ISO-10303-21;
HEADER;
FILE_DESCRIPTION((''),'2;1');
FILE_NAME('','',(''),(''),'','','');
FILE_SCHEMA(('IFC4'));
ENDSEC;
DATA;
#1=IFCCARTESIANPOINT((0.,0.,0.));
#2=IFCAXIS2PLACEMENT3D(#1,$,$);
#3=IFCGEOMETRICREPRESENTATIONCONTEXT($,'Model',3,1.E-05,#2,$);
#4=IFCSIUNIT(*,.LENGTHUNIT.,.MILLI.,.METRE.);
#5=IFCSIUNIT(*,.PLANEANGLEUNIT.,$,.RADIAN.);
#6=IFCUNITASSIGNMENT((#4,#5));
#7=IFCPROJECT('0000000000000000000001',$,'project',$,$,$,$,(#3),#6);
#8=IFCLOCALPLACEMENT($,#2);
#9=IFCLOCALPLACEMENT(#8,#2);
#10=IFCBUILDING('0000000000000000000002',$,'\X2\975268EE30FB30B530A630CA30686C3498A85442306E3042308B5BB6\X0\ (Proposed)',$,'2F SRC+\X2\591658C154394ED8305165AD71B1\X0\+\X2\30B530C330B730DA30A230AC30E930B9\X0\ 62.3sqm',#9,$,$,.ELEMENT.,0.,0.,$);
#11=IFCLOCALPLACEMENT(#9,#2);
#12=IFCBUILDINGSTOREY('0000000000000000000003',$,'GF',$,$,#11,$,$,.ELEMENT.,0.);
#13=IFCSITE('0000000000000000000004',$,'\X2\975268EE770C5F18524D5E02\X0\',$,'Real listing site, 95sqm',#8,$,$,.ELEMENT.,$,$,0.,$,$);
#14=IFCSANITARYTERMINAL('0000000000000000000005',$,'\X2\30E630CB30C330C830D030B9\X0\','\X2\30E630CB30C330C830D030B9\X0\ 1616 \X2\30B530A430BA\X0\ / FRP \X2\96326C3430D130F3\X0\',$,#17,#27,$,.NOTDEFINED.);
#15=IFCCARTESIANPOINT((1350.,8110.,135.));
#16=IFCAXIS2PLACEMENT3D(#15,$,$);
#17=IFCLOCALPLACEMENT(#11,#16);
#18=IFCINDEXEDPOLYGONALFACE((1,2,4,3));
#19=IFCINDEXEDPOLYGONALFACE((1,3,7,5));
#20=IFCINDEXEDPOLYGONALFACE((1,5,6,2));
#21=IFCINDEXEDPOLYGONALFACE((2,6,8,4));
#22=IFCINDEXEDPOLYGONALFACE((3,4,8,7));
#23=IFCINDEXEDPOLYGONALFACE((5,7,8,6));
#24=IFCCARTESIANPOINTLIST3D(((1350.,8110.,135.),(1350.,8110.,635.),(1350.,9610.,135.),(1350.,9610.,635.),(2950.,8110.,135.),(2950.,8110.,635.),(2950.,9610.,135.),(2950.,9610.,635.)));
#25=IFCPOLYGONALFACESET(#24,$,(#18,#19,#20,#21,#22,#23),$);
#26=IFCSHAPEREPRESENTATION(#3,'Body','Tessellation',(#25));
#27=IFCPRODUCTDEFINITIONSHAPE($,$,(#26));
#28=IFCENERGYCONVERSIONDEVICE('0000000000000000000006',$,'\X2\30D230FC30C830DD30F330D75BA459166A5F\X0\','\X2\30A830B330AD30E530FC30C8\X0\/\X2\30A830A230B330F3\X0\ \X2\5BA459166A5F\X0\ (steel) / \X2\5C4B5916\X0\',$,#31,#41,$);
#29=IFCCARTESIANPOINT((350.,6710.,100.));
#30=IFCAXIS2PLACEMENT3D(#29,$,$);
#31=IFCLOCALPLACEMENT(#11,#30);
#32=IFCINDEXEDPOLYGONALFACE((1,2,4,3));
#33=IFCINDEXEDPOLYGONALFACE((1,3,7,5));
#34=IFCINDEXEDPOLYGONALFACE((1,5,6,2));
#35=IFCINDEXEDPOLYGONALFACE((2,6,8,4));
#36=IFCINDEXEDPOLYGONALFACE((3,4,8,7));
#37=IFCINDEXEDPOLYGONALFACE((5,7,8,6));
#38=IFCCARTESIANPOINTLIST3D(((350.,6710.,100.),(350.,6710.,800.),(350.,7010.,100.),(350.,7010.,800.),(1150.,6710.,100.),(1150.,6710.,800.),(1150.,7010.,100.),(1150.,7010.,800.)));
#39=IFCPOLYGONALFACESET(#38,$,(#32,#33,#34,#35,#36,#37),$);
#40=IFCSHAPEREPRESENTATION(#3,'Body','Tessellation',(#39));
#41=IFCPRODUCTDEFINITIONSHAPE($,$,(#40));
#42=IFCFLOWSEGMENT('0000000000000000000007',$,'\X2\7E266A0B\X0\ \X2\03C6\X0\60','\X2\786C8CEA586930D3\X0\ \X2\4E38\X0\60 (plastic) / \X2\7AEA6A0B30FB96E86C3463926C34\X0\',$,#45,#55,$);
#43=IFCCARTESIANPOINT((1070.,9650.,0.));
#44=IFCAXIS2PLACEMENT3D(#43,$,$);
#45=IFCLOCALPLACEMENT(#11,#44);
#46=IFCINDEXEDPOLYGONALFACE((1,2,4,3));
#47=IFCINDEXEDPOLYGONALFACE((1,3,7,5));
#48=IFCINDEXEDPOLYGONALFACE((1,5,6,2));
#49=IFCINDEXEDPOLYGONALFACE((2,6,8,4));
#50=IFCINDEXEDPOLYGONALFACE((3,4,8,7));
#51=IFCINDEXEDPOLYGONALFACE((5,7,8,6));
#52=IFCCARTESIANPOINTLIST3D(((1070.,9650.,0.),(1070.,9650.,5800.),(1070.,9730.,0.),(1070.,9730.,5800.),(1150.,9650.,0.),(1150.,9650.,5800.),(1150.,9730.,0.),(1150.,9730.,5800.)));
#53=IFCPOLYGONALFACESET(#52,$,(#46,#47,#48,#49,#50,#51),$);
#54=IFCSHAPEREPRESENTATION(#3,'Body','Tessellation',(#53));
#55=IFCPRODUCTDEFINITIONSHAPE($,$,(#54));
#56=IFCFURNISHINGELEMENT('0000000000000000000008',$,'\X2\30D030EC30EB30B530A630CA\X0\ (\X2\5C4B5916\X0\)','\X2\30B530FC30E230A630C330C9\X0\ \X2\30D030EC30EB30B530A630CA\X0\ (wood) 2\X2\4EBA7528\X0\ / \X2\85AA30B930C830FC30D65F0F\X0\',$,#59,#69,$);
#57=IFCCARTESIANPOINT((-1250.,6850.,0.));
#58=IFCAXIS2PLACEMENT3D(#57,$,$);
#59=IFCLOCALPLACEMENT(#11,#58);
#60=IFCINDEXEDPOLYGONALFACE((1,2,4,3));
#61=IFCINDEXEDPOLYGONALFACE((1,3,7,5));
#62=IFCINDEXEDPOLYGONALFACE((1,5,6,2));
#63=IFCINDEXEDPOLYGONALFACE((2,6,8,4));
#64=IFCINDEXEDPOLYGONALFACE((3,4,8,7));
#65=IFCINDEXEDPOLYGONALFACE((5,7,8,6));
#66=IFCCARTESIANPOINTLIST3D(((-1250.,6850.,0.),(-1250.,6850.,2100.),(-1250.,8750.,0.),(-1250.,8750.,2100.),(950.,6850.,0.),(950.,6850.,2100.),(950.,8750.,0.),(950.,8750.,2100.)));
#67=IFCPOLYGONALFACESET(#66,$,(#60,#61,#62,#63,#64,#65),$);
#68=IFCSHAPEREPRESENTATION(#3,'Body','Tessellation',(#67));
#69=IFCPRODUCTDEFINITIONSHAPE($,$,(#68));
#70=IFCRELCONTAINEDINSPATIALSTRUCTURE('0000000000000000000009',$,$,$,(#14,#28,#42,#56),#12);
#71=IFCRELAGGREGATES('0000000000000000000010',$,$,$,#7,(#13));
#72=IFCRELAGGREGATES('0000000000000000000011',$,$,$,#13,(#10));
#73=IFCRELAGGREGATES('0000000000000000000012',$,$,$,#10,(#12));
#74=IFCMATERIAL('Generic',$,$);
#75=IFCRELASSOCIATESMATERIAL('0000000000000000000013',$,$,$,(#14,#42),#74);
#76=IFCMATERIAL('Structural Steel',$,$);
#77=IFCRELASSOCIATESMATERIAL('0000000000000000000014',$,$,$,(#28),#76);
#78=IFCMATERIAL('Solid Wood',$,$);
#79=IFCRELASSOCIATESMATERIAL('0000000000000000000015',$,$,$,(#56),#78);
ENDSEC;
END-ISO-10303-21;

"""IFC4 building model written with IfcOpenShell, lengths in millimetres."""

from ifc_helpers import new_model, si_unit, frame, frame_2d, origin, place, context, project, spatial, rectangle, extrude, material, element, save


model = new_model("IFC4")

# Units and contexts
model_context = context("Model", 3, precision=1e-05, world=origin())
ifc_project = project(units=[si_unit("LENGTHUNIT", "METRE", prefix="MILLI"), si_unit("PLANEANGLEUNIT", "RADIAN")], contexts=[model_context])

# Site, building, storey
site_placement = place(None, origin())
site = spatial("IfcSite", under=ifc_project, at=site_placement, Name="青森県弘前市", ObjectType="Real listing site, 95sqm", CompositionType="ELEMENT", RefElevation=0.0)
building_placement = place(site_placement, origin())
building = spatial("IfcBuilding", under=site, at=building_placement, Name="青森・サウナと水風呂のある家 (Proposed)", ObjectType="2F SRC+外壁吹付け断熱+サッシペアガラス 62.3sqm", CompositionType="ELEMENT", ElevationOfRefHeight=0.0, ElevationOfTerrain=0.0)
storey_placement = place(building_placement, origin())
storey = spatial("IfcBuildingStorey", under=building, at=storey_placement, Name="GF", CompositionType="ELEMENT", Elevation=0.0)

# Shared definitions
ifc_material_1 = material(Name="Solid Wood")

# Shared definitions
ifc_material_2 = material(Name="Generic")

# Sanitary terminal
sanitary_terminal_placement = place(storey_placement, frame((1350.0, 8110.0, 135.0)))
element("IfcSanitaryTerminal", 1, at=sanitary_terminal_placement, inside=storey, material=ifc_material_2, Name="ユニットバス", Description="ユニットバス 1616 サイズ / FRP 防水パン", PredefinedType="NOTDEFINED", context=model_context, shape_type="SweptSolid", body=[
    extrude(rectangle(XDim=1600.0, YDim=1500.0, at=frame_2d((800.0, 750.0))), frame((1350.0, 8110.0, 135.0)), (0.0, 0.0, 1.0), 500.0),
])

# Energy conversion device
ifc_material_3 = material(Name="Structural Steel")
energy_conversion_device_placement = place(storey_placement, frame((350.0, 6710.0, 100.0)))
element("IfcEnergyConversionDevice", 2, at=energy_conversion_device_placement, inside=storey, material=ifc_material_3, Name="ヒートポンプ室外機", Description="エコキュート/エアコン 室外機 (steel) / 屋外", context=model_context, shape_type="SweptSolid", body=[
    extrude(rectangle(XDim=800.0, YDim=300.0, at=frame_2d((400.0, 150.0))), frame((350.0, 6710.0, 100.0)), (0.0, 0.0, 1.0), 700.0),
])

# Flow segment
flow_segment_placement = place(storey_placement, frame((1070.0, 9650.0, 0.0)))
element("IfcFlowSegment", 3, at=flow_segment_placement, inside=storey, material=ifc_material_2, Name="縦樋 φ60", Description="硬質塩ビ 丸60 (plastic) / 竪樋・雨水排水", context=model_context, shape_type="SweptSolid", body=[
    extrude(rectangle(XDim=80.0, YDim=80.0, at=frame_2d((40.0, 40.0))), frame((1070.0, 9650.0, 0.0)), (0.0, 0.0, 1.0), 5800.0),
])

# Furnishing element
furnishing_placement = place(storey_placement, frame((-1250.0, 6850.0, 0.0)))
element("IfcFurnishingElement", 4, at=furnishing_placement, inside=storey, material=ifc_material_1, Name="バレルサウナ (屋外)", Description="サーモウッド バレルサウナ (wood) 2人用 / 薪ストーブ式", context=model_context, shape_type="SweptSolid", body=[
    extrude(rectangle(XDim=2200.0, YDim=1900.0, at=frame_2d((1100.0, 950.0))), frame((-1250.0, 6850.0, 0.0)), (0.0, 0.0, 1.0), 2100.0),
])

save(model, "model.ifc")
